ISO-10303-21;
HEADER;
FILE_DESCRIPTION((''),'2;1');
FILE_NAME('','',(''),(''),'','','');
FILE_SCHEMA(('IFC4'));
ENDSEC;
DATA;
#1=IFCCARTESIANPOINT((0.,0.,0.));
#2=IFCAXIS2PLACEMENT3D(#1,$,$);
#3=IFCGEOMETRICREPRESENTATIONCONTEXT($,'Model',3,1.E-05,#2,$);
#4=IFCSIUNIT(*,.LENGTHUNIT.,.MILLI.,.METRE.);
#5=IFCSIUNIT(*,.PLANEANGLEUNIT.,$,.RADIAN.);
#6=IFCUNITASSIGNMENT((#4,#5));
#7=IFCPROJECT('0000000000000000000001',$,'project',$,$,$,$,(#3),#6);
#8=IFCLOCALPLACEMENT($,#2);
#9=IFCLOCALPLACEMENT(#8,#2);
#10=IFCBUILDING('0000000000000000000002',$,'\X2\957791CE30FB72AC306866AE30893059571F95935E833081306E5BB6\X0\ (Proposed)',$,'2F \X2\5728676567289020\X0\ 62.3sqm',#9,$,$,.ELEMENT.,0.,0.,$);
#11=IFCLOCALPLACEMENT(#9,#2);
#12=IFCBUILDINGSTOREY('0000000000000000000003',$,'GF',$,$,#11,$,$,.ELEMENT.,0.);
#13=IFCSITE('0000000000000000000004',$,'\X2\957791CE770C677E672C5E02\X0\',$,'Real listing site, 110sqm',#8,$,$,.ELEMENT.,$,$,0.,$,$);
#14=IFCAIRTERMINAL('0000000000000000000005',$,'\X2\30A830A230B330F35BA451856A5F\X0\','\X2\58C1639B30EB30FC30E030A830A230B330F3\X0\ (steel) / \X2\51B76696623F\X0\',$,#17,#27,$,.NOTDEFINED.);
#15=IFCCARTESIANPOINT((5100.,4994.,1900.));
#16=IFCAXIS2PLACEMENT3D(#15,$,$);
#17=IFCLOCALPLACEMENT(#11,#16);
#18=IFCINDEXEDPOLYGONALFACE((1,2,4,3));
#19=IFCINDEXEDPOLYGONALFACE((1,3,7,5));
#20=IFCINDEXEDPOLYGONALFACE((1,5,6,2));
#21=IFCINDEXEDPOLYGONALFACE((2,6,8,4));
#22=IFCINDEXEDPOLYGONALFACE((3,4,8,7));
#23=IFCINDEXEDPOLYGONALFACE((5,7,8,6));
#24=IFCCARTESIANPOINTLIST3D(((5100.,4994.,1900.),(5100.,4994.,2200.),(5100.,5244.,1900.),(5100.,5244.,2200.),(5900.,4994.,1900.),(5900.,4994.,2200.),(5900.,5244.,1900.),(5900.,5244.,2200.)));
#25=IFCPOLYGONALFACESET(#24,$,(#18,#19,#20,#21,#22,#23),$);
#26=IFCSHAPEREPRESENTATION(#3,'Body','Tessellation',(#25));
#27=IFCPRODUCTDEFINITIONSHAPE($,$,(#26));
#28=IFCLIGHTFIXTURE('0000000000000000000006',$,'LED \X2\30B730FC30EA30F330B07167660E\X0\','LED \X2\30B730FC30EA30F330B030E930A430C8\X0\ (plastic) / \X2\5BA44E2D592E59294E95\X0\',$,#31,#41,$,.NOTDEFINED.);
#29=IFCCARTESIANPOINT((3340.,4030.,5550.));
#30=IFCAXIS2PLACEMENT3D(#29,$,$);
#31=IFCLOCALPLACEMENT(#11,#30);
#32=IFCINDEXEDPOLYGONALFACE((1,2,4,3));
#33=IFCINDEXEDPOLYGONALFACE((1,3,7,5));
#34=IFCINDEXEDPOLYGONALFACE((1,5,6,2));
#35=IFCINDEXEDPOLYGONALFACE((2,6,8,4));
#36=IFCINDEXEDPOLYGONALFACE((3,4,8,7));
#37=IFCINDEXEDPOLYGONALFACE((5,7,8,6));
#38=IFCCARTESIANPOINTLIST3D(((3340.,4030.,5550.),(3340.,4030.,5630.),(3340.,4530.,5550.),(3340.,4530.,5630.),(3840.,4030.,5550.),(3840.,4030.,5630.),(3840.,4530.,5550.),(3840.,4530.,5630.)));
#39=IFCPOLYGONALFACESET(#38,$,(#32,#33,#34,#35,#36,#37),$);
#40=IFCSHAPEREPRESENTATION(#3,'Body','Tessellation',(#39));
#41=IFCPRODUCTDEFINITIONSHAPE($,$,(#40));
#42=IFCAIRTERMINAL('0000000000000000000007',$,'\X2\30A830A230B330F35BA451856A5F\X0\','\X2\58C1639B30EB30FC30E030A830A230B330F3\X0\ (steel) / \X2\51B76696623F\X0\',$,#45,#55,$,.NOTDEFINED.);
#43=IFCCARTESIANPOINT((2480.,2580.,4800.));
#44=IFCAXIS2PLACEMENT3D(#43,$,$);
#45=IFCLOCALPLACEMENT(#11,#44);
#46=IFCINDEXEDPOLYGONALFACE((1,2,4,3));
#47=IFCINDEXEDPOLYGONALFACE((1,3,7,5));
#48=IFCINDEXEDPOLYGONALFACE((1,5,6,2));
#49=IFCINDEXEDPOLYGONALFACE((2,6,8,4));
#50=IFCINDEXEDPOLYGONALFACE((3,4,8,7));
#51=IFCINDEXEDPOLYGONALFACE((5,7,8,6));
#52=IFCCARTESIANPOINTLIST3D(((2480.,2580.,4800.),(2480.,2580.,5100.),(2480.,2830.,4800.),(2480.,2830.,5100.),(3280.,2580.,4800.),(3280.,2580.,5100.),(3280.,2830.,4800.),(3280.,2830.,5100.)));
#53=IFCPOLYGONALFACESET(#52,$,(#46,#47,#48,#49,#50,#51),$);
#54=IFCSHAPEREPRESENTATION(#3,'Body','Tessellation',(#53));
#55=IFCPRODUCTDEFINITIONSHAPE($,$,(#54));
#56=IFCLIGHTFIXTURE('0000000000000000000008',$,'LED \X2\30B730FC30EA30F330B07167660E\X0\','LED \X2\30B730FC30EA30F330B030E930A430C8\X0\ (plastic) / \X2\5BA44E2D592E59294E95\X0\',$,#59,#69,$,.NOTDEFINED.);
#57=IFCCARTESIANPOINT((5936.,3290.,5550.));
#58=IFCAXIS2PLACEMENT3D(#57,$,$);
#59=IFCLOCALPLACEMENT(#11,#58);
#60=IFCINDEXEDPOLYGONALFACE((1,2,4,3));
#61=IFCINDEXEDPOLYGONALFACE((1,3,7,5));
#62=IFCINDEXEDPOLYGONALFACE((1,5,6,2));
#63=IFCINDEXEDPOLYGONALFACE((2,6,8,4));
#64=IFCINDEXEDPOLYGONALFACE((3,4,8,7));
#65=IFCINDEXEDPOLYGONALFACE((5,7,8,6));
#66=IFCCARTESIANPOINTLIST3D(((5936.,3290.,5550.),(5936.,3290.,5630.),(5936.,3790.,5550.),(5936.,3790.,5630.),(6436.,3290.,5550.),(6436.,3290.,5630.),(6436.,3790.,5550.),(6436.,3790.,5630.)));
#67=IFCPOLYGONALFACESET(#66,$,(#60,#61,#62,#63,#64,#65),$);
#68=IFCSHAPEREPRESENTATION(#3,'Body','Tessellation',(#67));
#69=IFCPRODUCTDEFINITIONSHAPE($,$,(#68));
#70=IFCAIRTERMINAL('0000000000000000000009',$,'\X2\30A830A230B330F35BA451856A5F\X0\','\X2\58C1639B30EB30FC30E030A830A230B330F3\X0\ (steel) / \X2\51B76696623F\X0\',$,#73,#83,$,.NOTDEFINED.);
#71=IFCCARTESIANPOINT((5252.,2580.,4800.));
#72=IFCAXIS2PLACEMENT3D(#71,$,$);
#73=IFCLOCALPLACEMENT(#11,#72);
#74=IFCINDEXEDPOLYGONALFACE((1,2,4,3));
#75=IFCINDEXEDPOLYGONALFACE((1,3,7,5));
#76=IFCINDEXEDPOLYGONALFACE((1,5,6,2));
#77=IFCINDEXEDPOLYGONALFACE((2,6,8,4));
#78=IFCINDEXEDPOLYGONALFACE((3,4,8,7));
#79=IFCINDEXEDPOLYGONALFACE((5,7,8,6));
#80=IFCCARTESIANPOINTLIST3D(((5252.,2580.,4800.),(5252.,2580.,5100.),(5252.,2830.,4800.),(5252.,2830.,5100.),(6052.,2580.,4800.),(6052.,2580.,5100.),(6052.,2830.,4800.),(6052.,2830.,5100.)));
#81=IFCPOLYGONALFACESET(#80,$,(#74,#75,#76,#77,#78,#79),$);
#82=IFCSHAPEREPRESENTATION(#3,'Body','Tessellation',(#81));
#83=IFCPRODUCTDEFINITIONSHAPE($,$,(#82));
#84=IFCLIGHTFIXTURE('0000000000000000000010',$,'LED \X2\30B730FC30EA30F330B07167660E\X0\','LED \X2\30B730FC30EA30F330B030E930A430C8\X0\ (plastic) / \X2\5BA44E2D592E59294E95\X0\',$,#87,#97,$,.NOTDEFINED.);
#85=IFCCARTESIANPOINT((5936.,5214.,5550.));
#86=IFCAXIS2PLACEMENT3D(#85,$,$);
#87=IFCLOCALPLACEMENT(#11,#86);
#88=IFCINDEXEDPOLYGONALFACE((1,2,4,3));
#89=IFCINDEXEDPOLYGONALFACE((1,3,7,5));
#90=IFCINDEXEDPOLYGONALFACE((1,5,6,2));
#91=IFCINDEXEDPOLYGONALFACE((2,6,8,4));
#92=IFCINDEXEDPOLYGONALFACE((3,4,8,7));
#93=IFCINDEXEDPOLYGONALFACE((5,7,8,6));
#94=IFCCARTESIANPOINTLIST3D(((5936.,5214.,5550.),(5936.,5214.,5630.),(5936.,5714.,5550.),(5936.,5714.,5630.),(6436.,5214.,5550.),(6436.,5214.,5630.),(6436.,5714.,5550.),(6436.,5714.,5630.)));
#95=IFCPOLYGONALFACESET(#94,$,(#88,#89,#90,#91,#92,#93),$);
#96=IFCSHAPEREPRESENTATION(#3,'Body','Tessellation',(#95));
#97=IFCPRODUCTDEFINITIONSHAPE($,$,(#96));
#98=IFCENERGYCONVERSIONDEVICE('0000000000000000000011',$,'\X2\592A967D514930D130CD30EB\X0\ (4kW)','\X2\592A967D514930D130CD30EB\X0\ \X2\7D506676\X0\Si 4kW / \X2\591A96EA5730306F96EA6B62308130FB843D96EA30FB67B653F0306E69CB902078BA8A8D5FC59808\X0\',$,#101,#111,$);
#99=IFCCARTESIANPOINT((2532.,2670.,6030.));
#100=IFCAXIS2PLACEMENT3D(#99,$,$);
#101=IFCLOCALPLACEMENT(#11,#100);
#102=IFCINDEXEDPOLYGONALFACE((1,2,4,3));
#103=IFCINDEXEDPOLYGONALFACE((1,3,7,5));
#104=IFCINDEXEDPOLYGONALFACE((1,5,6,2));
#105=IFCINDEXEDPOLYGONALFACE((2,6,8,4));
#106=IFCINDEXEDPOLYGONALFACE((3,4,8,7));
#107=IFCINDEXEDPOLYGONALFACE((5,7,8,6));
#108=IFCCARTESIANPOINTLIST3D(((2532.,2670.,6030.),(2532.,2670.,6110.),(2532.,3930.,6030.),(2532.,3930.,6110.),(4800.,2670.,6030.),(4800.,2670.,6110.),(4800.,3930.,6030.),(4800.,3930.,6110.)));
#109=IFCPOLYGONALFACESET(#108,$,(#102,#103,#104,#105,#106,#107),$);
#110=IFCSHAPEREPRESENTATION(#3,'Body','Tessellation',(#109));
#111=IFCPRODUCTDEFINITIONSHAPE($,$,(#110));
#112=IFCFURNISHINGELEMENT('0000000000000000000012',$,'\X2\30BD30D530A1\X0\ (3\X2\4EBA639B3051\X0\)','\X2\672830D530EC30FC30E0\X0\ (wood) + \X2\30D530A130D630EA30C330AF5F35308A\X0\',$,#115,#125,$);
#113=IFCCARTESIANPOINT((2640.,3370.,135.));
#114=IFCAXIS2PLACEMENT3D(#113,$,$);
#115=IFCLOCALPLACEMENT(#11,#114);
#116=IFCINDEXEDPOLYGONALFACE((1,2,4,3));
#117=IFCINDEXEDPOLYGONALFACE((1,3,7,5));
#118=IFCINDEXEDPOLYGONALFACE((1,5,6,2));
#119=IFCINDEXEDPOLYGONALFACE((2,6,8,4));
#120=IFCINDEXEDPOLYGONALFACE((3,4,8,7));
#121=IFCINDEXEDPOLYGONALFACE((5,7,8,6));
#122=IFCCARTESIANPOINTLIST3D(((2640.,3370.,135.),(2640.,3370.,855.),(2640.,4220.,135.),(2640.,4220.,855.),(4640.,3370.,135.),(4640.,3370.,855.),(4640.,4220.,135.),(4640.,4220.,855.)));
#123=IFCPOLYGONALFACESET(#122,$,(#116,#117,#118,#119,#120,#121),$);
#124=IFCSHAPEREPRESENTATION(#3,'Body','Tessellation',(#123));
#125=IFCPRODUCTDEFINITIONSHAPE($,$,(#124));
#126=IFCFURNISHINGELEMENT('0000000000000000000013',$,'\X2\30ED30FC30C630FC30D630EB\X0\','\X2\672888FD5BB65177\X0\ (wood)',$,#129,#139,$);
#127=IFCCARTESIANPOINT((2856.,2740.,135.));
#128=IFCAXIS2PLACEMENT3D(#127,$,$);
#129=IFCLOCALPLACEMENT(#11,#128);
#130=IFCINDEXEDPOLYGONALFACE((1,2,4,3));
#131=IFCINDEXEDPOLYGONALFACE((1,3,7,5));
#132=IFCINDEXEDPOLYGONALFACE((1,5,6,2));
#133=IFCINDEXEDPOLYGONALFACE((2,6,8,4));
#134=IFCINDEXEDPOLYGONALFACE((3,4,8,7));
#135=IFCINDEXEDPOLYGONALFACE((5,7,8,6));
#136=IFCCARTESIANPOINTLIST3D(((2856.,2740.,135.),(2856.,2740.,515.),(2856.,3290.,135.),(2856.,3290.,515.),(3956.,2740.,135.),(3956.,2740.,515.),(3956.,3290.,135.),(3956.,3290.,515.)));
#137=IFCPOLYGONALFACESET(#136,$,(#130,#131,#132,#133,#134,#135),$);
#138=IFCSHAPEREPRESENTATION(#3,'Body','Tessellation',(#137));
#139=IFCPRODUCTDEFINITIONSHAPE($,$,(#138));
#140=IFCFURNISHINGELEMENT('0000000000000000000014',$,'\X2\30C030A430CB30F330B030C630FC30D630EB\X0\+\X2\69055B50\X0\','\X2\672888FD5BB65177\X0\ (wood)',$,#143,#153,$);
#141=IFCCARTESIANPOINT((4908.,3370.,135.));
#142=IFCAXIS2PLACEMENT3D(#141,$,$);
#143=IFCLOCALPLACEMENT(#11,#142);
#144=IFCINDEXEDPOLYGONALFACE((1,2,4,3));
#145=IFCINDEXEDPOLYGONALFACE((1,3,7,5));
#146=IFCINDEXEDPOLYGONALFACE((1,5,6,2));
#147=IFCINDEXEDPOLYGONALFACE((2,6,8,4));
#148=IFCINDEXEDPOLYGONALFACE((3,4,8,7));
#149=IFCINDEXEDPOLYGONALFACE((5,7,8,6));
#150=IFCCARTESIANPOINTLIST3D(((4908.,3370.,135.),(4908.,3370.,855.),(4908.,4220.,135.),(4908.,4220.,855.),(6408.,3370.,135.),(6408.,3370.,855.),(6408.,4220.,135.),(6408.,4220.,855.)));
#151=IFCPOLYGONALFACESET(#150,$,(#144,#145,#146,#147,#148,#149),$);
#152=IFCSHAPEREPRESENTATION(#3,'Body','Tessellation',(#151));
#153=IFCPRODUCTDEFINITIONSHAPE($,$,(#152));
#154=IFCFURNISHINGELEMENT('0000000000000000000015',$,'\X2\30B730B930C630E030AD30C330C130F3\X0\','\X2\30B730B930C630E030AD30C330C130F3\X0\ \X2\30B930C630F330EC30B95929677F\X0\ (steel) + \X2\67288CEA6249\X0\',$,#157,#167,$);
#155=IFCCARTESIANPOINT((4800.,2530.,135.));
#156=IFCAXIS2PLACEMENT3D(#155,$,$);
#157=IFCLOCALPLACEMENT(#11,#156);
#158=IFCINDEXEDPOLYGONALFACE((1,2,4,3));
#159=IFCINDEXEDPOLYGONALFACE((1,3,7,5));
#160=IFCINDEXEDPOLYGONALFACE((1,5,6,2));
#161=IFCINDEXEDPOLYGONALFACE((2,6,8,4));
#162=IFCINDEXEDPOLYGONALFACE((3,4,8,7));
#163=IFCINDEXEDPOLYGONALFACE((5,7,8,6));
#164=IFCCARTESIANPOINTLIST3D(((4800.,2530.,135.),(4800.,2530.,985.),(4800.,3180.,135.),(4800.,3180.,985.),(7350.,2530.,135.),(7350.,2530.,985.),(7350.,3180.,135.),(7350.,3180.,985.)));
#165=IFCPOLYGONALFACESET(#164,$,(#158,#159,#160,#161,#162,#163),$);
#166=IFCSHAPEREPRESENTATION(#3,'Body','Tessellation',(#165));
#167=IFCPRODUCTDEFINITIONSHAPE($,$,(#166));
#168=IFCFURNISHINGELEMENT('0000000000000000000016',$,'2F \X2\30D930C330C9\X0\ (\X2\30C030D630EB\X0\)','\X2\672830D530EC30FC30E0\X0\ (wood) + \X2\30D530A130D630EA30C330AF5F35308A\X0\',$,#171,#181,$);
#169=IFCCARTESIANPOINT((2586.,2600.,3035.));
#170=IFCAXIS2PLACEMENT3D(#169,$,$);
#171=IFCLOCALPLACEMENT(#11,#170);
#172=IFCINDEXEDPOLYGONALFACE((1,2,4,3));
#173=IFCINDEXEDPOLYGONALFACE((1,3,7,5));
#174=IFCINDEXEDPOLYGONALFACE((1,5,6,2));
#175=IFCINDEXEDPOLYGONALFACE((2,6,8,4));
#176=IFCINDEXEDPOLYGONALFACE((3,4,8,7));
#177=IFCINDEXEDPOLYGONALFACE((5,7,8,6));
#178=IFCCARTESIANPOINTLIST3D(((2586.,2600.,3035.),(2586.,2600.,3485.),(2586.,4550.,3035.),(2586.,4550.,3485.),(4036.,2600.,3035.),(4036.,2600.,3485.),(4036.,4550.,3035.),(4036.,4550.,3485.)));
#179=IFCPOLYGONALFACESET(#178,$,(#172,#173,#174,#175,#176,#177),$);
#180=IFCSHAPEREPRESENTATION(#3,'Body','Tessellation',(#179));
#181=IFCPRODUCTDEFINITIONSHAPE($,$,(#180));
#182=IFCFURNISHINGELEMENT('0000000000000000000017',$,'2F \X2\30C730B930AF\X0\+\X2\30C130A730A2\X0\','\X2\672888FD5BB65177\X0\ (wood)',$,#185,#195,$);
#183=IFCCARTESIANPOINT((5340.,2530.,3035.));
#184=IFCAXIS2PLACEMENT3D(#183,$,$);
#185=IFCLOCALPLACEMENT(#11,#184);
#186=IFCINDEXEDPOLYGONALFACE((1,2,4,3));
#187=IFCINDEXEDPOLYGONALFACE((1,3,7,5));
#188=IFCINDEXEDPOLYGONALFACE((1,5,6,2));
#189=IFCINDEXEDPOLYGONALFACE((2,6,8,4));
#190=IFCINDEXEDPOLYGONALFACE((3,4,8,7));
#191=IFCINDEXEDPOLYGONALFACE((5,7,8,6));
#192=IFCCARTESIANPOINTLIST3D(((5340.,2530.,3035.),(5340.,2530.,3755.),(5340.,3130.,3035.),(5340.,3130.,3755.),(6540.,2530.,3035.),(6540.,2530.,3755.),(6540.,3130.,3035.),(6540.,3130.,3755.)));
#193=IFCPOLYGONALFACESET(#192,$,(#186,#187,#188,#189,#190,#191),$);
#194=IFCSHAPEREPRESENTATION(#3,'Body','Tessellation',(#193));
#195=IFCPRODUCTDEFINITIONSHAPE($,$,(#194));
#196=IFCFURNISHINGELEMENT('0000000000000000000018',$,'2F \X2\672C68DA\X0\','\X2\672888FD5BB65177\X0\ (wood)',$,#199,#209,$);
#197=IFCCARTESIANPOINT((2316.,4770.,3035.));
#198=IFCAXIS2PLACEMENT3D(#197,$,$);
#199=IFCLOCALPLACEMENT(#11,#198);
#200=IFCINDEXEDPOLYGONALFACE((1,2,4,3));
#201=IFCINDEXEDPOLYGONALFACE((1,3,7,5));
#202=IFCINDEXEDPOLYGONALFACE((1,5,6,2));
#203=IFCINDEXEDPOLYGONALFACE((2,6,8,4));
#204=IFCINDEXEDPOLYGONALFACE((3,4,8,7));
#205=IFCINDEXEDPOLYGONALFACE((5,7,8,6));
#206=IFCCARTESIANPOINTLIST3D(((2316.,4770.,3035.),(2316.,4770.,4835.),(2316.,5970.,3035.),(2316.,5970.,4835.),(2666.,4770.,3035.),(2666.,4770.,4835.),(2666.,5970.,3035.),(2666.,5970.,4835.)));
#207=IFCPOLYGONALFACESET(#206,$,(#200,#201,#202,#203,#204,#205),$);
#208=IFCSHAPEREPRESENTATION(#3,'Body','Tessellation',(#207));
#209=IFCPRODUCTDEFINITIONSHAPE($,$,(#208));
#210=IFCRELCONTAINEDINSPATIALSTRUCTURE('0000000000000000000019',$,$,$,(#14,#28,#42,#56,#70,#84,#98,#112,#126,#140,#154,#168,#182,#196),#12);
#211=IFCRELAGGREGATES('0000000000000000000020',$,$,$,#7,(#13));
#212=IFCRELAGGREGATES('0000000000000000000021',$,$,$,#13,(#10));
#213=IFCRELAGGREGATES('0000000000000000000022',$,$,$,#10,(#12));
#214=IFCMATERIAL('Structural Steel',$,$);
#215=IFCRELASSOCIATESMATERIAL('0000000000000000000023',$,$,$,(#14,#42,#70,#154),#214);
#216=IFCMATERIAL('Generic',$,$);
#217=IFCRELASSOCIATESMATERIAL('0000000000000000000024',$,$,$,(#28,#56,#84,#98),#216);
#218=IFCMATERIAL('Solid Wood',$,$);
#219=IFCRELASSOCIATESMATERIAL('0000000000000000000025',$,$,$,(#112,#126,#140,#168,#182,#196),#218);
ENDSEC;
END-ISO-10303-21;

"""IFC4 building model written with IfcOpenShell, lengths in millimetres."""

from ifc_helpers import new_model, si_unit, frame, frame_2d, origin, place, context, project, spatial, rectangle, extrude, material, element, save


model = new_model("IFC4")

# Units and contexts
model_context = context("Model", 3, precision=1e-05, world=origin())
ifc_project = project(units=[si_unit("LENGTHUNIT", "METRE", prefix="MILLI"), si_unit("PLANEANGLEUNIT", "RADIAN")], contexts=[model_context])

# Site, building, storey
site_placement = place(None, origin())
site = spatial("IfcSite", under=ifc_project, at=site_placement, Name="長野県松本市", ObjectType="Real listing site, 110sqm", CompositionType="ELEMENT", RefElevation=0.0)
building_placement = place(site_placement, origin())
building = spatial("IfcBuilding", under=site, at=building_placement, Name="長野・犬と暮らす土間広めの家 (Proposed)", ObjectType="2F 在来木造 62.3sqm", CompositionType="ELEMENT", ElevationOfRefHeight=0.0, ElevationOfTerrain=0.0)
storey_placement = place(building_placement, origin())
storey = spatial("IfcBuildingStorey", under=building, at=storey_placement, Name="GF", CompositionType="ELEMENT", Elevation=0.0)

# Shared definitions
ifc_material_1 = material(Name="Solid Wood")

# Shared definitions
ifc_material_2 = material(Name="Structural Steel")

# Shared definitions
ifc_material_3 = material(Name="Generic")

# Air terminal
air_terminal_1_placement = place(storey_placement, frame((5100.0, 4994.0, 1900.0)))
element("IfcAirTerminal", 1, at=air_terminal_1_placement, inside=storey, material=ifc_material_2, Name="エアコン室内機", Description="壁掛ルームエアコン (steel) / 冷暖房", PredefinedType="NOTDEFINED", context=model_context, shape_type="SweptSolid", body=[
    extrude(rectangle(XDim=800.0, YDim=250.0, at=frame_2d((400.0, 125.0))), frame((5100.0, 4994.0, 1900.0)), (0.0, 0.0, 1.0), 300.0),
])

# Light fixture
light_fixture_1_placement = place(storey_placement, frame((3340.0, 4030.0, 5550.0)))
element("IfcLightFixture", 2, at=light_fixture_1_placement, inside=storey, material=ifc_material_3, Name="LED シーリング照明", Description="LED シーリングライト (plastic) / 室中央天井", PredefinedType="NOTDEFINED", context=model_context, shape_type="SweptSolid", body=[
    extrude(rectangle(XDim=500.0, YDim=500.0, at=frame_2d((250.0, 250.0))), frame((3340.0, 4030.0, 5550.0)), (0.0, 0.0, 1.0), 80.0),
])

# Air terminal
air_terminal_2_placement = place(storey_placement, frame((2480.0, 2580.0, 4800.0)))
element("IfcAirTerminal", 3, at=air_terminal_2_placement, inside=storey, material=ifc_material_2, Name="エアコン室内機", Description="壁掛ルームエアコン (steel) / 冷暖房", PredefinedType="NOTDEFINED", context=model_context, shape_type="SweptSolid", body=[
    extrude(rectangle(XDim=800.0, YDim=250.0, at=frame_2d((400.0, 125.0))), frame((2480.0, 2580.0, 4800.0)), (0.0, 0.0, 1.0), 300.0),
])

# Light fixture
light_fixture_2_placement = place(storey_placement, frame((5936.0, 3290.0, 5550.0)))
element("IfcLightFixture", 4, at=light_fixture_2_placement, inside=storey, material=ifc_material_3, Name="LED シーリング照明", Description="LED シーリングライト (plastic) / 室中央天井", PredefinedType="NOTDEFINED", context=model_context, shape_type="SweptSolid", body=[
    extrude(rectangle(XDim=500.0, YDim=500.0, at=frame_2d((250.0, 250.0))), frame((5936.0, 3290.0, 5550.0)), (0.0, 0.0, 1.0), 80.0),
])

# Air terminal
air_terminal_3_placement = place(storey_placement, frame((5252.0, 2580.0, 4800.0)))
element("IfcAirTerminal", 5, at=air_terminal_3_placement, inside=storey, material=ifc_material_2, Name="エアコン室内機", Description="壁掛ルームエアコン (steel) / 冷暖房", PredefinedType="NOTDEFINED", context=model_context, shape_type="SweptSolid", body=[
    extrude(rectangle(XDim=800.0, YDim=250.0, at=frame_2d((400.0, 125.0))), frame((5252.0, 2580.0, 4800.0)), (0.0, 0.0, 1.0), 300.0),
])

# Light fixture
light_fixture_3_placement = place(storey_placement, frame((5936.0, 5214.0, 5550.0)))
element("IfcLightFixture", 6, at=light_fixture_3_placement, inside=storey, material=ifc_material_3, Name="LED シーリング照明", Description="LED シーリングライト (plastic) / 室中央天井", PredefinedType="NOTDEFINED", context=model_context, shape_type="SweptSolid", body=[
    extrude(rectangle(XDim=500.0, YDim=500.0, at=frame_2d((250.0, 250.0))), frame((5936.0, 5214.0, 5550.0)), (0.0, 0.0, 1.0), 80.0),
])

# Energy conversion device
energy_conversion_device_placement = place(storey_placement, frame((2532.0, 2670.0, 6030.0)))
element("IfcEnergyConversionDevice", 7, at=energy_conversion_device_placement, inside=storey, material=ifc_material_3, Name="太陽光パネル (4kW)", Description="太陽光パネル 結晶Si 4kW / 多雪地は雪止め・落雪・架台の構造確認必須", context=model_context, shape_type="SweptSolid", body=[
    extrude(rectangle(XDim=2268.0, YDim=1260.0, at=frame_2d((1134.0, 630.0))), frame((2532.0, 2670.0, 6030.0)), (0.0, 0.0, 1.0), 80.0),
])

# Furnishing elements
furnishing_1_placement = place(storey_placement, frame((2640.0, 3370.0, 135.0)))
element("IfcFurnishingElement", 8, at=furnishing_1_placement, inside=storey, material=ifc_material_1, Name="ソファ (3人掛け)", Description="木フレーム (wood) + ファブリック張り", context=model_context, shape_type="SweptSolid", body=[
    extrude(rectangle(XDim=2000.0, YDim=850.0, at=frame_2d((1000.0, 425.0))), frame((2640.0, 3370.0, 135.0)), (0.0, 0.0, 1.0), 720.0),
])
furnishing_2_placement = place(storey_placement, frame((2856.0, 2740.0, 135.0)))
element("IfcFurnishingElement", 9, at=furnishing_2_placement, inside=storey, material=ifc_material_1, Name="ローテーブル", Description="木製家具 (wood)", context=model_context, shape_type="SweptSolid", body=[
    extrude(rectangle(XDim=1100.0, YDim=550.0, at=frame_2d((550.0, 275.0))), frame((2856.0, 2740.0, 135.0)), (0.0, 0.0, 1.0), 380.0),
])
furnishing_3_placement = place(storey_placement, frame((4908.0, 3370.0, 135.0)))
element("IfcFurnishingElement", 10, at=furnishing_3_placement, inside=storey, material=ifc_material_1, Name="ダイニングテーブル+椅子", Description="木製家具 (wood)", context=model_context, shape_type="SweptSolid", body=[
    extrude(rectangle(XDim=1500.0, YDim=850.0, at=frame_2d((750.0, 425.0))), frame((4908.0, 3370.0, 135.0)), (0.0, 0.0, 1.0), 720.0),
])
furnishing_4_placement = place(storey_placement, frame((4800.0, 2530.0, 135.0)))
element("IfcFurnishingElement", 11, at=furnishing_4_placement, inside=storey, material=ifc_material_2, Name="システムキッチン", Description="システムキッチン ステンレス天板 (steel) + 木質扉", context=model_context, shape_type="SweptSolid", body=[
    extrude(rectangle(XDim=2550.0, YDim=650.0, at=frame_2d((1275.0, 325.0))), frame((4800.0, 2530.0, 135.0)), (0.0, 0.0, 1.0), 850.0),
])
furnishing_5_placement = place(storey_placement, frame((2586.0, 2600.0, 3035.0)))
element("IfcFurnishingElement", 12, at=furnishing_5_placement, inside=storey, material=ifc_material_1, Name="2F ベッド (ダブル)", Description="木フレーム (wood) + ファブリック張り", context=model_context, shape_type="SweptSolid", body=[
    extrude(rectangle(XDim=1450.0, YDim=1950.0, at=frame_2d((725.0, 975.0))), frame((2586.0, 2600.0, 3035.0)), (0.0, 0.0, 1.0), 450.0),
])
furnishing_6_placement = place(storey_placement, frame((5340.0, 2530.0, 3035.0)))
element("IfcFurnishingElement", 13, at=furnishing_6_placement, inside=storey, material=ifc_material_1, Name="2F デスク+チェア", Description="木製家具 (wood)", context=model_context, shape_type="SweptSolid", body=[
    extrude(rectangle(XDim=1200.0, YDim=600.0, at=frame_2d((600.0, 300.0))), frame((5340.0, 2530.0, 3035.0)), (0.0, 0.0, 1.0), 720.0),
])
furnishing_7_placement = place(storey_placement, frame((2316.0, 4770.0, 3035.0)))
element("IfcFurnishingElement", 14, at=furnishing_7_placement, inside=storey, material=ifc_material_1, Name="2F 本棚", Description="木製家具 (wood)", context=model_context, shape_type="SweptSolid", body=[
    extrude(rectangle(XDim=350.0, YDim=1200.0, at=frame_2d((175.0, 600.0))), frame((2316.0, 4770.0, 3035.0)), (0.0, 0.0, 1.0), 1800.0),
])

save(model, "model.ifc")
